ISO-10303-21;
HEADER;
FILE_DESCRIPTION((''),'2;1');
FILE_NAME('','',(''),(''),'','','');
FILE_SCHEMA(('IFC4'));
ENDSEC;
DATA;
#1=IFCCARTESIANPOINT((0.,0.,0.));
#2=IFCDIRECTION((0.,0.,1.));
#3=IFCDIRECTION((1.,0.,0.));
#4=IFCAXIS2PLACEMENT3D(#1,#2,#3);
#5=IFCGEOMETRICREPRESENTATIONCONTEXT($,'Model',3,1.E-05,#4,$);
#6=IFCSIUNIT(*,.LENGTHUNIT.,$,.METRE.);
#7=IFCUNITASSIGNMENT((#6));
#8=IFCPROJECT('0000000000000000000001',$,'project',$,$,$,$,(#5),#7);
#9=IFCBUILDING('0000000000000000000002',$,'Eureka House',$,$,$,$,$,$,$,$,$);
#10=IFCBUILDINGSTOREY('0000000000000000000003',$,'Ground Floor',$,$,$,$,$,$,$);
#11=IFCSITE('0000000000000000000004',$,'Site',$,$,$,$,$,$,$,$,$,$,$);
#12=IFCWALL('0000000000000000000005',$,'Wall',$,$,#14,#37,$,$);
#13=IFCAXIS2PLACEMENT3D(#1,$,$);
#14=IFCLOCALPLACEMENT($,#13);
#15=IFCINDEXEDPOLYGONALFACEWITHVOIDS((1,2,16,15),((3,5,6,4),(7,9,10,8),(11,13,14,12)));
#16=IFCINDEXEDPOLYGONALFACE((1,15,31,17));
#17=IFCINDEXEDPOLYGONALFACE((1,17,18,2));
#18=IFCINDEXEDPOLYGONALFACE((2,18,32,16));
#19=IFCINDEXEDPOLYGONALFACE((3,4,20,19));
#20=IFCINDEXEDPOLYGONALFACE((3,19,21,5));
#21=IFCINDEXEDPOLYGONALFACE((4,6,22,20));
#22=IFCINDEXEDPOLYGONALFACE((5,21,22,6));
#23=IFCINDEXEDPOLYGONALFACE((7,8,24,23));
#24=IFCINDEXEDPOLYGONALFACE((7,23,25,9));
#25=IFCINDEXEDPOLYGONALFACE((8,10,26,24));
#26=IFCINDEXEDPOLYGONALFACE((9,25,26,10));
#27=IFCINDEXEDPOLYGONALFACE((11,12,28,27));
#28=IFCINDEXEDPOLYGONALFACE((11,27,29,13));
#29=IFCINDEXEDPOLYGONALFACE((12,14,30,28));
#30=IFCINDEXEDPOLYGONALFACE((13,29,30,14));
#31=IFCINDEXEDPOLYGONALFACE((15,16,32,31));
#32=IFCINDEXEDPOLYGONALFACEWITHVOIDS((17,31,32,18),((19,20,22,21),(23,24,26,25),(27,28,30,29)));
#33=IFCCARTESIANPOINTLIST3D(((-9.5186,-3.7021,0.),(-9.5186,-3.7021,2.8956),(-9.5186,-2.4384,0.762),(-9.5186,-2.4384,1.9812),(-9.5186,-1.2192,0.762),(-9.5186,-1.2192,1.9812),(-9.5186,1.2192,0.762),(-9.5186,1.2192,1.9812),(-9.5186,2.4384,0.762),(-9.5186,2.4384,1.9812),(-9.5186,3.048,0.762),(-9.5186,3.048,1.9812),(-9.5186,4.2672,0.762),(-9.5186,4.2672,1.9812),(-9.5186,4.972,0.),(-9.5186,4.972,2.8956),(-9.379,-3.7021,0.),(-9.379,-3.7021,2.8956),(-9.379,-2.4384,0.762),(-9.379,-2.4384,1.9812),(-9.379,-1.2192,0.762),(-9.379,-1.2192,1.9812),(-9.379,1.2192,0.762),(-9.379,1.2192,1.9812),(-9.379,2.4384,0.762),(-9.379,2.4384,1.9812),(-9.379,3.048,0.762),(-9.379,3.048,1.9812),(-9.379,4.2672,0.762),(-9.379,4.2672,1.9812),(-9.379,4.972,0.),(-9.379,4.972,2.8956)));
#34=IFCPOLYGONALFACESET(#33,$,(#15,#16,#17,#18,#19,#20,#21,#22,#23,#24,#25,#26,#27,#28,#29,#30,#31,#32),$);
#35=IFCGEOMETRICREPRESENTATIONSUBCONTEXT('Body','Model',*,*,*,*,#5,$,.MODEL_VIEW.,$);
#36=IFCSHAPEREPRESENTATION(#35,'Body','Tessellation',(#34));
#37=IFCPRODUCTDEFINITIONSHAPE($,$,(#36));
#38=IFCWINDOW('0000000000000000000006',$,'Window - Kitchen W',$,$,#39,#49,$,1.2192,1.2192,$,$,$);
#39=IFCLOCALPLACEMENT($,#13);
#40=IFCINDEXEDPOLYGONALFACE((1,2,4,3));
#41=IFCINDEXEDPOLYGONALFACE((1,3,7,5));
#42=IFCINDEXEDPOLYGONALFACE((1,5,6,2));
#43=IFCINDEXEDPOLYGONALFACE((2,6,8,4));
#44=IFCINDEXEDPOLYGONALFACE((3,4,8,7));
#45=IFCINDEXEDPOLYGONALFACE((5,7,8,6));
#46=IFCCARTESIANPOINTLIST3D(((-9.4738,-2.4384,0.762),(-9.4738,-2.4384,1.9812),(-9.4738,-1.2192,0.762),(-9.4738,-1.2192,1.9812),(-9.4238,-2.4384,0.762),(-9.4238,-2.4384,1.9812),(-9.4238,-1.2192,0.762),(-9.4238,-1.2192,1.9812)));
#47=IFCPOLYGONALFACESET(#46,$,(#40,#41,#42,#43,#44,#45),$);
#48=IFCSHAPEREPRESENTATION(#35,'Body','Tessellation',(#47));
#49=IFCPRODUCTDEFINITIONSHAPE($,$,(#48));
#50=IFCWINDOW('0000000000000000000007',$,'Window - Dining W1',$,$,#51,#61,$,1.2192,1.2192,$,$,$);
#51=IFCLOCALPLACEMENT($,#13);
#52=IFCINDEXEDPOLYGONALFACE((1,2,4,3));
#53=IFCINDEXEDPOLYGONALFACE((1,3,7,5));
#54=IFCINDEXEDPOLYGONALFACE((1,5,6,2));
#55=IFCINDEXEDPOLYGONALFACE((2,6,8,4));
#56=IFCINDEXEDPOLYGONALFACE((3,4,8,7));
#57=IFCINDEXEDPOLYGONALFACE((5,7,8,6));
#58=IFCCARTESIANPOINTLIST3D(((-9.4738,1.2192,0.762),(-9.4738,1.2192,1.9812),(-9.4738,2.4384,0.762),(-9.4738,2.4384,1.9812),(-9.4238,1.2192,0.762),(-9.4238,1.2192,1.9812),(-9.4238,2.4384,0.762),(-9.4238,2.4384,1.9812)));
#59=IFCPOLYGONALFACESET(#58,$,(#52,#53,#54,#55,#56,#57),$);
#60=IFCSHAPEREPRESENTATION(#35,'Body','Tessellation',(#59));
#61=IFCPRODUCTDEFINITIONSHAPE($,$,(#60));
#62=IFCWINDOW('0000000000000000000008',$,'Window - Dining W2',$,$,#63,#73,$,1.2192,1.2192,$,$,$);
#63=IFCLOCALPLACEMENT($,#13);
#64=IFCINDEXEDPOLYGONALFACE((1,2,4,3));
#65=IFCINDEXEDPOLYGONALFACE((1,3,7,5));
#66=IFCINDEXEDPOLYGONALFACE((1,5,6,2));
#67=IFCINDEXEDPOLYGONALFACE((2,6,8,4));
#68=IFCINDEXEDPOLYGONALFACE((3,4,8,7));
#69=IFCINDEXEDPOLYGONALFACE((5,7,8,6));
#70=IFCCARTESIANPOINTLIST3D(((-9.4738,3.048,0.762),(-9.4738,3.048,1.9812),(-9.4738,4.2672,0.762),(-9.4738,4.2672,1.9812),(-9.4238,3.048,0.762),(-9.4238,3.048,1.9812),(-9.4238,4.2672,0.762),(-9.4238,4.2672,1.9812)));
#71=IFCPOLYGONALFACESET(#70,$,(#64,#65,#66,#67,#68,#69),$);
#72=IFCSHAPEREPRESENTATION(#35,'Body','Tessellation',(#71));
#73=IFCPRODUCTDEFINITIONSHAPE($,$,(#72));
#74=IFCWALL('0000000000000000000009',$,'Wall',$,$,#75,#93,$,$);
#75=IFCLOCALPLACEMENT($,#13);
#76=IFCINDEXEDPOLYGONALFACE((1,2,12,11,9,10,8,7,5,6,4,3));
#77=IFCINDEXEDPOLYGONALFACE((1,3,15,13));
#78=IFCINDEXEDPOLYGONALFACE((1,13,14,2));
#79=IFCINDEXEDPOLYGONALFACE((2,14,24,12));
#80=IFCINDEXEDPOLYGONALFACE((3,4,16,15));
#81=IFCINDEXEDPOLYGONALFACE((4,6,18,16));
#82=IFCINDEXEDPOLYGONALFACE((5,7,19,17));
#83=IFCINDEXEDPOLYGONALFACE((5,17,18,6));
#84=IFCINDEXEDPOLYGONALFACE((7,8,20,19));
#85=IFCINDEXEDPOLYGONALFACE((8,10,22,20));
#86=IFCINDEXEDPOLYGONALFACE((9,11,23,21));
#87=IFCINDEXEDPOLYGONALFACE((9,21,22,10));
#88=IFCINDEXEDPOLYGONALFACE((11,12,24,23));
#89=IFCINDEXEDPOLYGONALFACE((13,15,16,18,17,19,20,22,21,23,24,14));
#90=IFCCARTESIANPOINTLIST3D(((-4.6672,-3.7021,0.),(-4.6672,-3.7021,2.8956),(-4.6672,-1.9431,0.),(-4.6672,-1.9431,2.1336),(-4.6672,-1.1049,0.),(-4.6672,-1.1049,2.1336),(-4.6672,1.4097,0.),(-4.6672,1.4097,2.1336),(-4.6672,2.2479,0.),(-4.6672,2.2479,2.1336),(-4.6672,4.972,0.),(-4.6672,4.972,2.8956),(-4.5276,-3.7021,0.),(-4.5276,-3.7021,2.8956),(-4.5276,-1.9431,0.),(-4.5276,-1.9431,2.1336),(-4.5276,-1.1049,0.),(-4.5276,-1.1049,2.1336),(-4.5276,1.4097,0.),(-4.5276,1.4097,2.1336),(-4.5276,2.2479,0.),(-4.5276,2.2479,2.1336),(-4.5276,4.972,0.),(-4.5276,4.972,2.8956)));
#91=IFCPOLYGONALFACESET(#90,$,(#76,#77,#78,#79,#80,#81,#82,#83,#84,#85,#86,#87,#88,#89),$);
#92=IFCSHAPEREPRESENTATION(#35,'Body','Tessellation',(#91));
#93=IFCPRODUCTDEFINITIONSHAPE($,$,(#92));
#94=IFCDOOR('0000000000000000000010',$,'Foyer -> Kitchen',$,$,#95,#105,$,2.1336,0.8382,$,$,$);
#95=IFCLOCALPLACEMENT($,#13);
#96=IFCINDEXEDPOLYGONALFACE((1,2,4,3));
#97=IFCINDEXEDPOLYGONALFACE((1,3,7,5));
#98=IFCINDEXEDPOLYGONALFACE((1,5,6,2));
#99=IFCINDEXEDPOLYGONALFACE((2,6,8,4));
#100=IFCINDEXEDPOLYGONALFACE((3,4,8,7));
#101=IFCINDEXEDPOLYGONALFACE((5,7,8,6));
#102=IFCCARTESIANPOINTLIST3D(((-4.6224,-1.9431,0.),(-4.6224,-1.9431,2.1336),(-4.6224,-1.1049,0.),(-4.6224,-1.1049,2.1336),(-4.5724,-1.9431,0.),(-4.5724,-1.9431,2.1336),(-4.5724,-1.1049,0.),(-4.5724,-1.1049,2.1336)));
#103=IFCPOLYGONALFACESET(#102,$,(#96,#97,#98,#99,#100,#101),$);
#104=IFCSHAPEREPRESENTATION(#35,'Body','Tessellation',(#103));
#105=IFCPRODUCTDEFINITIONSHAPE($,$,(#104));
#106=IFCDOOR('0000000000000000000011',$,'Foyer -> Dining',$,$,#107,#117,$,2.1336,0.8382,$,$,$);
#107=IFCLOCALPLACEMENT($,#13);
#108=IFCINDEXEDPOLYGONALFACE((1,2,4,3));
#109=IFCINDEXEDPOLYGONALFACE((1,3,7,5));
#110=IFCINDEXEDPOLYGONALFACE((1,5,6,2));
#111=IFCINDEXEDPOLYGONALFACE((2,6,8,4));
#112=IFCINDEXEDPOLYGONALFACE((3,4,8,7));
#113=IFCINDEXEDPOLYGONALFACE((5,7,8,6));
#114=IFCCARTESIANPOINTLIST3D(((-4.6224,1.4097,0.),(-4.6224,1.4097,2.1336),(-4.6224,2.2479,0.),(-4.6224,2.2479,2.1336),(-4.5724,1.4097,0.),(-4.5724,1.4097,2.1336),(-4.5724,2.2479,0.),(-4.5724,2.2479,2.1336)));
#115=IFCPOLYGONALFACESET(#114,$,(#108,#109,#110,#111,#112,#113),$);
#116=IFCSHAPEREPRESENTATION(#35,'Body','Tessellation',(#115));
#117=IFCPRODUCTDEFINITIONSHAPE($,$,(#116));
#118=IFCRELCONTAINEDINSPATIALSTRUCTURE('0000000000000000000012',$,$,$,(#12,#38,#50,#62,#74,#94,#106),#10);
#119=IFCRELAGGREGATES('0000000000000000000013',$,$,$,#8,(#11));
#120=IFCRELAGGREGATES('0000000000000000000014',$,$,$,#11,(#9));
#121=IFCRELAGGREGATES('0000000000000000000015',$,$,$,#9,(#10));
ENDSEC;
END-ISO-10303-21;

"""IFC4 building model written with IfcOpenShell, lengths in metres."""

from ifc_helpers import new_model, si_unit, frame, origin, origin_with_axes, origin_2d, place, context, subcontext, project, spatial, rectangle, extrude, element, fill, save


model = new_model("IFC4")

# Units and contexts
model_context = context("Model", 3, precision=1e-05, world=origin_with_axes())
body_context = subcontext(model_context, "Body", "Model", "MODEL_VIEW")
ifc_project = project(units=[si_unit("LENGTHUNIT", "METRE")], contexts=[model_context])

# Site, building, storey
site = spatial("IfcSite", under=ifc_project, Name="Site")
building = spatial("IfcBuilding", under=site, Name="Eureka House")
storey = spatial("IfcBuildingStorey", under=building, Name="Ground Floor")

# Wall, openings, windows
wall_1_placement = place(None, frame((-9.4488, 0.635, 0.0), z_axis=(0.0, 0.0, 1.0), x_axis=(1.0, 0.0, 0.0)))
wall_1 = element("IfcWall", 1, at=wall_1_placement, inside=storey, Name="Wall", context=body_context, shape_type="SweptSolid", body=[
    extrude(rectangle(XDim=0.1397, YDim=8.6741, at=origin_2d()), origin(), (0.0, 0.0, 1.0), 2.8956),
])
opening_1_placement = place(wall_1_placement, frame((0.0, -2.4638, 0.762), z_axis=(0.0, 0.0, 1.0), x_axis=(1.0, 0.0, 0.0)))
opening_1 = element("IfcOpeningElement", 2, at=opening_1_placement, cuts=wall_1, context=body_context, shape_type="SweptSolid", body=[
    extrude(rectangle(XDim=0.2397, YDim=1.2192, at=origin_2d()), origin(), (0.0, 0.0, 1.0), 1.2192),
])
opening_2_placement = place(wall_1_placement, frame((0.0, 1.1938, 0.762), z_axis=(0.0, 0.0, 1.0), x_axis=(1.0, 0.0, 0.0)))
opening_2 = element("IfcOpeningElement", 3, at=opening_2_placement, cuts=wall_1, context=body_context, shape_type="SweptSolid", body=[
    extrude(rectangle(XDim=0.2397, YDim=1.2192, at=origin_2d()), origin(), (0.0, 0.0, 1.0), 1.2192),
])
opening_3_placement = place(wall_1_placement, frame((0.0, 3.0226, 0.762), z_axis=(0.0, 0.0, 1.0), x_axis=(1.0, 0.0, 0.0)))
opening_3 = element("IfcOpeningElement", 4, at=opening_3_placement, cuts=wall_1, context=body_context, shape_type="SweptSolid", body=[
    extrude(rectangle(XDim=0.2397, YDim=1.2192, at=origin_2d()), origin(), (0.0, 0.0, 1.0), 1.2192),
])
window_1_placement = place(opening_1_placement, origin_with_axes())
window_1 = element("IfcWindow", 5, at=window_1_placement, inside=storey, Name="Window - Kitchen W", OverallHeight=1.2192, OverallWidth=1.2192, context=body_context, shape_type="SweptSolid", body=[
    extrude(rectangle(XDim=0.05, YDim=1.2192, at=origin_2d()), origin(), (0.0, 0.0, 1.0), 1.2192),
])
fill(opening_1, window_1)
window_2_placement = place(opening_2_placement, origin_with_axes())
window_2 = element("IfcWindow", 6, at=window_2_placement, inside=storey, Name="Window - Dining W1", OverallHeight=1.2192, OverallWidth=1.2192, context=body_context, shape_type="SweptSolid", body=[
    extrude(rectangle(XDim=0.05, YDim=1.2192, at=origin_2d()), origin(), (0.0, 0.0, 1.0), 1.2192),
])
fill(opening_2, window_2)
window_3_placement = place(opening_3_placement, origin_with_axes())
window_3 = element("IfcWindow", 7, at=window_3_placement, inside=storey, Name="Window - Dining W2", OverallHeight=1.2192, OverallWidth=1.2192, context=body_context, shape_type="SweptSolid", body=[
    extrude(rectangle(XDim=0.05, YDim=1.2192, at=origin_2d()), origin(), (0.0, 0.0, 1.0), 1.2192),
])
fill(opening_3, window_3)

# Wall, openings, doors
wall_2_placement = place(None, frame((-4.5974, 0.635, 0.0), z_axis=(0.0, 0.0, 1.0), x_axis=(1.0, 0.0, 0.0)))
wall_2 = element("IfcWall", 8, at=wall_2_placement, inside=storey, Name="Wall", context=body_context, shape_type="SweptSolid", body=[
    extrude(rectangle(XDim=0.1397, YDim=8.6741, at=origin_2d()), origin(), (0.0, 0.0, 1.0), 2.8956),
])
opening_4_placement = place(wall_2_placement, frame((0.0, -2.159, 0.0), z_axis=(0.0, 0.0, 1.0), x_axis=(1.0, 0.0, 0.0)))
opening_4 = element("IfcOpeningElement", 9, at=opening_4_placement, cuts=wall_2, context=body_context, shape_type="SweptSolid", body=[
    extrude(rectangle(XDim=0.2397, YDim=0.8382, at=origin_2d()), origin(), (0.0, 0.0, 1.0), 2.1336),
])
opening_5_placement = place(wall_2_placement, frame((0.0, 1.1938, 0.0), z_axis=(0.0, 0.0, 1.0), x_axis=(1.0, 0.0, 0.0)))
opening_5 = element("IfcOpeningElement", 10, at=opening_5_placement, cuts=wall_2, context=body_context, shape_type="SweptSolid", body=[
    extrude(rectangle(XDim=0.2397, YDim=0.8382, at=origin_2d()), origin(), (0.0, 0.0, 1.0), 2.1336),
])
door_1_placement = place(opening_4_placement, origin_with_axes())
door_1 = element("IfcDoor", 11, at=door_1_placement, inside=storey, Name="Foyer -> Kitchen", OverallHeight=2.1336, OverallWidth=0.8382, context=body_context, shape_type="SweptSolid", body=[
    extrude(rectangle(XDim=0.05, YDim=0.8382, at=origin_2d()), origin(), (0.0, 0.0, 1.0), 2.1336),
])
fill(opening_4, door_1)
door_2_placement = place(opening_5_placement, origin_with_axes())
door_2 = element("IfcDoor", 12, at=door_2_placement, inside=storey, Name="Foyer -> Dining", OverallHeight=2.1336, OverallWidth=0.8382, context=body_context, shape_type="SweptSolid", body=[
    extrude(rectangle(XDim=0.05, YDim=0.8382, at=origin_2d()), origin(), (0.0, 0.0, 1.0), 2.1336),
])
fill(opening_5, door_2)

save(model, "model.ifc")
